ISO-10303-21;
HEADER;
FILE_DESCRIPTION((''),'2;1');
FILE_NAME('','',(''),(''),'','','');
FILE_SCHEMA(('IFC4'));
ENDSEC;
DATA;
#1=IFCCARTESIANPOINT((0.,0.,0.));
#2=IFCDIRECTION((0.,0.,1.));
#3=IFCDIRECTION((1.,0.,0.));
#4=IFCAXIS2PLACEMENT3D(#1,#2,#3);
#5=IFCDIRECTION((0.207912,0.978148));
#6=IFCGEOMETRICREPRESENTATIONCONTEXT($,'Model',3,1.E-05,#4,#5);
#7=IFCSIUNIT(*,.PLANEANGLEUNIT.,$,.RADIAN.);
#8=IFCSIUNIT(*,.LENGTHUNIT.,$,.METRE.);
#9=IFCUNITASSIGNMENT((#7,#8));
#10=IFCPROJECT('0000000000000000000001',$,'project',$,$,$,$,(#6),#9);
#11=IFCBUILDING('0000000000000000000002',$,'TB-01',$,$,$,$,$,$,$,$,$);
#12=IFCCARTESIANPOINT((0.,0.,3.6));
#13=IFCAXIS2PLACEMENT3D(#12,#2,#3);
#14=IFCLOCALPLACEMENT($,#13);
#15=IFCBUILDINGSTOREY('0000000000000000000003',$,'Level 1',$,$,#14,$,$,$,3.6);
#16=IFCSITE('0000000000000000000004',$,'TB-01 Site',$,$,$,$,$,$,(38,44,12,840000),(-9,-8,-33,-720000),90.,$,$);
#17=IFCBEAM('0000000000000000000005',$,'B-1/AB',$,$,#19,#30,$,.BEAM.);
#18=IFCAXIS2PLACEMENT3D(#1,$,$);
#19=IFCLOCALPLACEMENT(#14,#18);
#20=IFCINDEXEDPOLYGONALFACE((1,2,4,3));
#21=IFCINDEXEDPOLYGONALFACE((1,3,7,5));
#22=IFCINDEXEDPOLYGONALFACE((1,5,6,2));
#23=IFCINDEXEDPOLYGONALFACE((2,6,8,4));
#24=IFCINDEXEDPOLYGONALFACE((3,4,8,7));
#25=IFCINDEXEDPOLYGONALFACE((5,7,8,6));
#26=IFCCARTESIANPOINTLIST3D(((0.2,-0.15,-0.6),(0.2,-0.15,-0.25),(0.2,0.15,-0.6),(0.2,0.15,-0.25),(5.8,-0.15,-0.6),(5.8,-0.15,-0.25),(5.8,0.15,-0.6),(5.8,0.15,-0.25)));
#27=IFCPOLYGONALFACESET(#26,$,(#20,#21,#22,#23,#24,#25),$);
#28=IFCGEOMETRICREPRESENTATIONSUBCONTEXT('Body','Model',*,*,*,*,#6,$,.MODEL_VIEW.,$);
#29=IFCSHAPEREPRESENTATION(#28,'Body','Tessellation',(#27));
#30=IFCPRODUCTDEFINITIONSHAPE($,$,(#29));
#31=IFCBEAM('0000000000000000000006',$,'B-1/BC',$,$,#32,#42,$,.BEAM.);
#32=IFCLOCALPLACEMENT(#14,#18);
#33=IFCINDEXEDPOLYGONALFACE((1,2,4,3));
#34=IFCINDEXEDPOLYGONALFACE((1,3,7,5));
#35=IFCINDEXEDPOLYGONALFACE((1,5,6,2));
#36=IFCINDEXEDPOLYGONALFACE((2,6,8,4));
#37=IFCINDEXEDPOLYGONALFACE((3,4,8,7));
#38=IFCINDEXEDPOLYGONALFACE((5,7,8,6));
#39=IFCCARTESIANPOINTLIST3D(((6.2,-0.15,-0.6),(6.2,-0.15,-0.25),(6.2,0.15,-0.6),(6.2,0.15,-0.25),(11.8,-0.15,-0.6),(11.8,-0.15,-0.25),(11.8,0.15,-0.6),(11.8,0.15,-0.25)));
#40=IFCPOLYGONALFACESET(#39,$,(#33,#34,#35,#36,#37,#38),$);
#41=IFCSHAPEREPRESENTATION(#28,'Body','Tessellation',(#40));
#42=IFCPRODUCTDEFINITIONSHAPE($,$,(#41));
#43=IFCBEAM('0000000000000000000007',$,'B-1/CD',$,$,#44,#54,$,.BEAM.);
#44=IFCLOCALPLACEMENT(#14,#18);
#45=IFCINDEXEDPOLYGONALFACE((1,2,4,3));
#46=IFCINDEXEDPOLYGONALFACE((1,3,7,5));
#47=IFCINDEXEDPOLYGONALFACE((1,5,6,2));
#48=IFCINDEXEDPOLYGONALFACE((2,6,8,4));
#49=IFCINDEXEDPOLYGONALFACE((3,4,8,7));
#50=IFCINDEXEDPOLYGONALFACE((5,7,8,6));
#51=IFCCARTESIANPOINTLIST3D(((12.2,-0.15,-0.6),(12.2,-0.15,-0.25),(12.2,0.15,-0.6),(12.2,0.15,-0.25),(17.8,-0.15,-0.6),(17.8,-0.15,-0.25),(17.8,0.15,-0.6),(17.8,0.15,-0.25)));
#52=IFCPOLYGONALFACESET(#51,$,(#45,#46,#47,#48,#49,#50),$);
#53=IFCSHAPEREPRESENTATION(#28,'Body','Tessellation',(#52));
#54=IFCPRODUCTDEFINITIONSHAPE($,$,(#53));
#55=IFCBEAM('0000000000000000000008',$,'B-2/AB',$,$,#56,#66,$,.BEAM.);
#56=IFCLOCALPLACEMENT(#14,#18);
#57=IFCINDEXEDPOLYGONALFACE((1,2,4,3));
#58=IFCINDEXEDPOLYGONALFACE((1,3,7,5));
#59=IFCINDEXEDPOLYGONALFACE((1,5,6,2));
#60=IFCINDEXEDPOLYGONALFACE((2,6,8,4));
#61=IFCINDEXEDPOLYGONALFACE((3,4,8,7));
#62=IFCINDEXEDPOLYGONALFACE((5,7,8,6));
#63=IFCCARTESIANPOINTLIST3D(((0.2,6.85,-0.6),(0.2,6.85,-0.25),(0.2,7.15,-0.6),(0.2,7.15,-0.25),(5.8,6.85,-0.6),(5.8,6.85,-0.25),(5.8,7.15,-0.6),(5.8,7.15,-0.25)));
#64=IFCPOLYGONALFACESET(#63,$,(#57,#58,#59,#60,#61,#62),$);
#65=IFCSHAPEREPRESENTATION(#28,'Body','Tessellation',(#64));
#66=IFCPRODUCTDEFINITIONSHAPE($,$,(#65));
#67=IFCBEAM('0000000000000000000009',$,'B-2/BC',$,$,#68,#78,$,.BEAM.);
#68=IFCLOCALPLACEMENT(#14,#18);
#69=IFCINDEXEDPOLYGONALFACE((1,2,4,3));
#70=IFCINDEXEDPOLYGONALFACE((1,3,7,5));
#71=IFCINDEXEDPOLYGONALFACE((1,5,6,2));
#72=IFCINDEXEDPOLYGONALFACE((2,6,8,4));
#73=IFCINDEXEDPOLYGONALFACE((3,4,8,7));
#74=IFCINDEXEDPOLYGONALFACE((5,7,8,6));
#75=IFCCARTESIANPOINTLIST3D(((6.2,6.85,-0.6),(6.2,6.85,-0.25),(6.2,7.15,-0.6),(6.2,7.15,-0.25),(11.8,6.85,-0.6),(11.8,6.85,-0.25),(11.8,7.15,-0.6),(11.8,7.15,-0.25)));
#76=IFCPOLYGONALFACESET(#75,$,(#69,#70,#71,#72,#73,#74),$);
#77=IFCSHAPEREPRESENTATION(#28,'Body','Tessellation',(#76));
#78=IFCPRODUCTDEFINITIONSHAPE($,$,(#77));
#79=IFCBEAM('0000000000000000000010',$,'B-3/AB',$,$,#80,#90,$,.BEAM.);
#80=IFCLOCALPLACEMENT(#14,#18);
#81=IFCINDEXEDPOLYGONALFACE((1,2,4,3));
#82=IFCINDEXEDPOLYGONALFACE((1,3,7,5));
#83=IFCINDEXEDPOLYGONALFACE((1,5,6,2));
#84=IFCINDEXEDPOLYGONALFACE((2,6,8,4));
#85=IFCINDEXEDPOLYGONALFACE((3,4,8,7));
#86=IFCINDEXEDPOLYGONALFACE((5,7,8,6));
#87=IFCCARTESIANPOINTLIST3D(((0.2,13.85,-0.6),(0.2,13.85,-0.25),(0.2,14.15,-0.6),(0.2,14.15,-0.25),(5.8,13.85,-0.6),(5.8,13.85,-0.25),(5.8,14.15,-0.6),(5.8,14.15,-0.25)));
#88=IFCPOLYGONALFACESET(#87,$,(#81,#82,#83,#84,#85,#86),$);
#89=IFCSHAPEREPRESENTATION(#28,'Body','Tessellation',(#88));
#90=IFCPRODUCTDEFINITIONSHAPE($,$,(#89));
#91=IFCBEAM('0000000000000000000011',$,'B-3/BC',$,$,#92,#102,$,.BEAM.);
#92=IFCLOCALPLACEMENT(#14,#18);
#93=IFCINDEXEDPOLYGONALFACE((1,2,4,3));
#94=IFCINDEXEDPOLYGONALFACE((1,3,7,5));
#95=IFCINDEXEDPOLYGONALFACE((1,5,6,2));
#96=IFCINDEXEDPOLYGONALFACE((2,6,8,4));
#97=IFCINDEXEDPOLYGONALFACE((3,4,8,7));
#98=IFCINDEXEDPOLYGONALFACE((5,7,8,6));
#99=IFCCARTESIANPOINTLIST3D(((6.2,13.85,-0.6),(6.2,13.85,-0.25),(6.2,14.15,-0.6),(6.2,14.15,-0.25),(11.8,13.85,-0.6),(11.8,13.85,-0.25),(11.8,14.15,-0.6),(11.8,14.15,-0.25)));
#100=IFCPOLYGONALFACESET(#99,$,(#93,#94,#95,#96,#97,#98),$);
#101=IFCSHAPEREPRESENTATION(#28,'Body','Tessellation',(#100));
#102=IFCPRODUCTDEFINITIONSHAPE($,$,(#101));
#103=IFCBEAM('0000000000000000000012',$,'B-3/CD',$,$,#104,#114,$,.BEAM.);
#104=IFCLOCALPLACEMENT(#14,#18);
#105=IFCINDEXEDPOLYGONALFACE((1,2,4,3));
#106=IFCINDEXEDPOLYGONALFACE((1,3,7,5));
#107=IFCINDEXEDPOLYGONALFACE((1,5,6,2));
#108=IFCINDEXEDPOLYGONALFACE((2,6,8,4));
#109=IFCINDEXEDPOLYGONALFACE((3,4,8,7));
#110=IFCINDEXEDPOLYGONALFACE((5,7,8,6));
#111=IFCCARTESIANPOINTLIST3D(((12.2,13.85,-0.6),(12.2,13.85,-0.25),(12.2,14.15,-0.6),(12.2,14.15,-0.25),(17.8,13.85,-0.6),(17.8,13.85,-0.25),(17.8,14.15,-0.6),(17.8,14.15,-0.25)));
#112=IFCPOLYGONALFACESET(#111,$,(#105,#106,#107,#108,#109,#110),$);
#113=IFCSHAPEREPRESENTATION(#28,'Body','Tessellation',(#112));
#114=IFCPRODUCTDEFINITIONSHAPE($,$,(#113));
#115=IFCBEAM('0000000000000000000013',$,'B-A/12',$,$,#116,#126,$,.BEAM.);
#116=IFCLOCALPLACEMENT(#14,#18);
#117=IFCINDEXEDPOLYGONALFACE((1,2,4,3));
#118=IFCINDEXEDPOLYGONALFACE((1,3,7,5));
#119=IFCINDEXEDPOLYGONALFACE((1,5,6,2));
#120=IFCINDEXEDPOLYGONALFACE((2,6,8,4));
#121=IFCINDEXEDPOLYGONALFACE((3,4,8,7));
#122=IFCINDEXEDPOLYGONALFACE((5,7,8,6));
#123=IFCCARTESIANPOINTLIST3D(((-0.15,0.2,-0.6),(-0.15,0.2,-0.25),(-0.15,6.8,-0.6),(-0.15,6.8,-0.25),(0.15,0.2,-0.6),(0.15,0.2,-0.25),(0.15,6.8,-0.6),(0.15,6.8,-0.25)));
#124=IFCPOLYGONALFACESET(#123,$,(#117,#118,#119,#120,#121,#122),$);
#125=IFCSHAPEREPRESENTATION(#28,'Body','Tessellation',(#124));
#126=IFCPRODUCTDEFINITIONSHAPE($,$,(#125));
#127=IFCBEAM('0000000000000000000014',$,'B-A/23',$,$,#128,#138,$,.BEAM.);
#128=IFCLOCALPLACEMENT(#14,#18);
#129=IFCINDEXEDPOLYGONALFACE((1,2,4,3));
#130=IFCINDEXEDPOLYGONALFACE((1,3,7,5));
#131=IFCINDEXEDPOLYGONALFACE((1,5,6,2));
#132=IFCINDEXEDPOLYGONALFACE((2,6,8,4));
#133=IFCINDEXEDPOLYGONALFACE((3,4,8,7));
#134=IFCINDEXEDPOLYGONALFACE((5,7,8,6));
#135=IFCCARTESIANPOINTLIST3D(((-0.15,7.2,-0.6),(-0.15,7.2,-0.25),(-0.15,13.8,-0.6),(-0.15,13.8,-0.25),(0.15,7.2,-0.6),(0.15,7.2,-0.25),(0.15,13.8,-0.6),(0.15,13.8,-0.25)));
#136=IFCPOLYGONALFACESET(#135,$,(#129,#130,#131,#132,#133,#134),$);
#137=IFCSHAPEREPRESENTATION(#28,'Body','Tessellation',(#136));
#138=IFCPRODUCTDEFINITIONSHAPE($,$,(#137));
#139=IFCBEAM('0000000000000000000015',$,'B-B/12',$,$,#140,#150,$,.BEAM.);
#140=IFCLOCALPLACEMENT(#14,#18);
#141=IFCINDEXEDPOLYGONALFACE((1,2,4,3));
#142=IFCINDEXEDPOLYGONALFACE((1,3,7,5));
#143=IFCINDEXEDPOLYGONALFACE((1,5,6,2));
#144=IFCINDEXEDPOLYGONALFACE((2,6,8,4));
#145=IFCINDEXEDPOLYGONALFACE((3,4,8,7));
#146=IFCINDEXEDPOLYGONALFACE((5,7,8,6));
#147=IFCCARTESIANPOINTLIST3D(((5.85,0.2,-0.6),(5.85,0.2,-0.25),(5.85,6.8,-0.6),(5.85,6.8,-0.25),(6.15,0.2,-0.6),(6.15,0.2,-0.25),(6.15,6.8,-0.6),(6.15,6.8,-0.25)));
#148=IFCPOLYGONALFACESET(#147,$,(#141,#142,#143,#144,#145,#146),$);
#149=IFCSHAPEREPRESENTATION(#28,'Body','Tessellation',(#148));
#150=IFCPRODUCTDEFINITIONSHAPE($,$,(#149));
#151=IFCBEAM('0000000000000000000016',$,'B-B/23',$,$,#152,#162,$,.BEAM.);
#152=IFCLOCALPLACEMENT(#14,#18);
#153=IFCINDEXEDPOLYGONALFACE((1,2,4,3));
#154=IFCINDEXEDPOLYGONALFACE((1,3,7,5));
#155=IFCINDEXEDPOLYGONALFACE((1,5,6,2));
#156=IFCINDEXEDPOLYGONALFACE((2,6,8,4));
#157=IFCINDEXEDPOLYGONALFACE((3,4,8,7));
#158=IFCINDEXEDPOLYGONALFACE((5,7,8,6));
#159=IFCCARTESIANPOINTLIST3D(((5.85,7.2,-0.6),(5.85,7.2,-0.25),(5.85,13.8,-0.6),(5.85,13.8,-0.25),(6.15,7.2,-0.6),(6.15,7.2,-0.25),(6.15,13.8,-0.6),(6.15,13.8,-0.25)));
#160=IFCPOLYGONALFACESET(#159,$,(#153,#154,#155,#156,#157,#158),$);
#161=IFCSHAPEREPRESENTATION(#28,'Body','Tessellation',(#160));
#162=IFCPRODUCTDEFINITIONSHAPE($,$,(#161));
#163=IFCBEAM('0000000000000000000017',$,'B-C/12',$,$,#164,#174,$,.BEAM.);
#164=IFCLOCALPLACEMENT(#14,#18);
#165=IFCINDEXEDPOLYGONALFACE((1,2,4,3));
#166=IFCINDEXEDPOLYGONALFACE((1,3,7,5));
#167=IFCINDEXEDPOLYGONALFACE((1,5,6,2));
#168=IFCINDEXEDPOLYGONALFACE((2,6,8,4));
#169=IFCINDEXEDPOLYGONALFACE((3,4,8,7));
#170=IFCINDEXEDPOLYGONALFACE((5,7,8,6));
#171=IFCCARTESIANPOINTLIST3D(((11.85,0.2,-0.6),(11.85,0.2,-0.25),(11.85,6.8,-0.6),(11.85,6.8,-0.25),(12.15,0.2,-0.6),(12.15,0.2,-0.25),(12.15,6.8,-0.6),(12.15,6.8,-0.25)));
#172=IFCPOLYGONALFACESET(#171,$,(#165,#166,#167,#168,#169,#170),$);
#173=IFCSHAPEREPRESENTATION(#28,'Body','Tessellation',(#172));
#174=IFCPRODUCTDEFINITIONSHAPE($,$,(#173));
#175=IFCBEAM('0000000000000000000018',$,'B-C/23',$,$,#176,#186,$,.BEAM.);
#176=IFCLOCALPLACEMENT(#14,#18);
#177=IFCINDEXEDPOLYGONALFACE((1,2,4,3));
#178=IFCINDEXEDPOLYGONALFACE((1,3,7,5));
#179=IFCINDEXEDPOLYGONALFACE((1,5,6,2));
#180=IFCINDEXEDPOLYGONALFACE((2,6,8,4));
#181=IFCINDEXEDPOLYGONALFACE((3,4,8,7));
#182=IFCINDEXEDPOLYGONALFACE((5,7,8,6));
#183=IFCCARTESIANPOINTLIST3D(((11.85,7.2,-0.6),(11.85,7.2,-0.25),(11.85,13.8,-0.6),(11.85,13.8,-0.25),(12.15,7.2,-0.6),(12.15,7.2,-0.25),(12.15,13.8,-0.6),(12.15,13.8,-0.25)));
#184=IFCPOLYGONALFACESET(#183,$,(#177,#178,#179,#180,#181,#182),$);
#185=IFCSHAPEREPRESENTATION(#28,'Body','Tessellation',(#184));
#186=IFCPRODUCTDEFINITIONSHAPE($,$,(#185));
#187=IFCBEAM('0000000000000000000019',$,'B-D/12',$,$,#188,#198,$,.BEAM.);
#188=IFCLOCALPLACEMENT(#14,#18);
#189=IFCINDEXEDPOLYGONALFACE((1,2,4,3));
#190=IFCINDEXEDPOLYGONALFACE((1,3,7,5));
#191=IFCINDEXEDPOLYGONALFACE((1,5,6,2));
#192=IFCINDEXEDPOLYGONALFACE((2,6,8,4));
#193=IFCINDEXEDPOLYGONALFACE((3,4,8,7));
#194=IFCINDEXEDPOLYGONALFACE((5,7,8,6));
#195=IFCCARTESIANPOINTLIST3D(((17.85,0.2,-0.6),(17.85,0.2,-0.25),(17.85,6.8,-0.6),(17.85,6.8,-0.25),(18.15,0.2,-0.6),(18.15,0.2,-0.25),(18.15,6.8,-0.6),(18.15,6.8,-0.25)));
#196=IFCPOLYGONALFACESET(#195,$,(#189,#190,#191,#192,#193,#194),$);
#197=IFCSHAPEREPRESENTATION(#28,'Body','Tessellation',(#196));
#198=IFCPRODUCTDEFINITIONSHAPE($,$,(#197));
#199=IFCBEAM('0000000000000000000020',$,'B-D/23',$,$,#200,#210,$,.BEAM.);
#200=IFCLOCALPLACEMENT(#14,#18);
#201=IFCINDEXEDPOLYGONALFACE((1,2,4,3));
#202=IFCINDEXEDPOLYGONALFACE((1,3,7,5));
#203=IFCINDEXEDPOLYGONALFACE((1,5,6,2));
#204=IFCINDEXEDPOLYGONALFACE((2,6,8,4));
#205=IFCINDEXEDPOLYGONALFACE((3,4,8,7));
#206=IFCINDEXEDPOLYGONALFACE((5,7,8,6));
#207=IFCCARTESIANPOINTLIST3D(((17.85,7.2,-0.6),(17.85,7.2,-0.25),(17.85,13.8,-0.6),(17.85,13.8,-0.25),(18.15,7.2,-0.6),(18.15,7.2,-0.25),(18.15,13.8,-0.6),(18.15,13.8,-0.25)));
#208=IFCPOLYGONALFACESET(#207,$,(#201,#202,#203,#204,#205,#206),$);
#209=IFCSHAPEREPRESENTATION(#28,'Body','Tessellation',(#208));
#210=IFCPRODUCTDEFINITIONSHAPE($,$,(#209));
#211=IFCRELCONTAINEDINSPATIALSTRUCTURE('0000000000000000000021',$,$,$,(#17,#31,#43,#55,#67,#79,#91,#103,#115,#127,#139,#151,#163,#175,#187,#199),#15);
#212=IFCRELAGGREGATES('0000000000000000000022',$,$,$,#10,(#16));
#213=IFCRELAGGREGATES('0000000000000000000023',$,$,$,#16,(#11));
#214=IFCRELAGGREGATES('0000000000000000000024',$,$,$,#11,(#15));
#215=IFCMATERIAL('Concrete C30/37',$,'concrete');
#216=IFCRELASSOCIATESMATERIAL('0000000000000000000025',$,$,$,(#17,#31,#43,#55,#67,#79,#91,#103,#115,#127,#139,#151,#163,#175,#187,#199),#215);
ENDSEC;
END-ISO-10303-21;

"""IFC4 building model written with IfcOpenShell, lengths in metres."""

from ifc_helpers import new_model, si_unit, direction, frame, origin_with_axes, place, context, subcontext, project, spatial, rectangle, extrude, material, element, save


model = new_model("IFC4")

# Units and contexts
model_context = context("Model", 3, precision=1e-05, world=origin_with_axes(), true_north=direction((0.207912, 0.978148)))
body_context = subcontext(model_context, "Body", "Model", "MODEL_VIEW")
ifc_project = project(units=[si_unit("PLANEANGLEUNIT", "RADIAN"), si_unit("LENGTHUNIT", "METRE")], contexts=[model_context])

# Site, building, storey
site = spatial("IfcSite", under=ifc_project, Name="TB-01 Site", RefLatitude=(38, 44, 12, 840000), RefLongitude=(-9, -8, -33, -720000), RefElevation=90.0)
building = spatial("IfcBuilding", under=site, Name="TB-01")
storey_placement = place(None, frame((0.0, 0.0, 3.6), z_axis=(0.0, 0.0, 1.0), x_axis=(1.0, 0.0, 0.0)))
storey = spatial("IfcBuildingStorey", under=building, at=storey_placement, Name="Level 1", Elevation=3.6)

# Beams
ifc_material = material(Name="Concrete C30/37", Category="concrete")
beam_1_placement = place(storey_placement, frame((0.2, 0.0, -0.425), z_axis=(1.0, 0.0, 0.0), x_axis=(0.0, 1.0, 0.0)))
element("IfcBeam", 1, at=beam_1_placement, inside=storey, material=ifc_material, Name="B-1/AB", PredefinedType="BEAM", context=body_context, shape_type="SweptSolid", body=[
    extrude(rectangle(XDim=0.3, YDim=0.35), origin_with_axes(), (0.0, 0.0, 1.0), 5.6),
])
beam_2_placement = place(storey_placement, frame((6.2, 0.0, -0.425), z_axis=(1.0, 0.0, 0.0), x_axis=(0.0, 1.0, 0.0)))
element("IfcBeam", 2, at=beam_2_placement, inside=storey, material=ifc_material, Name="B-1/BC", PredefinedType="BEAM", context=body_context, shape_type="SweptSolid", body=[
    extrude(rectangle(XDim=0.3, YDim=0.35), origin_with_axes(), (0.0, 0.0, 1.0), 5.6),
])
beam_3_placement = place(storey_placement, frame((12.2, 0.0, -0.425), z_axis=(1.0, 0.0, 0.0), x_axis=(0.0, 1.0, 0.0)))
element("IfcBeam", 3, at=beam_3_placement, inside=storey, material=ifc_material, Name="B-1/CD", PredefinedType="BEAM", context=body_context, shape_type="SweptSolid", body=[
    extrude(rectangle(XDim=0.3, YDim=0.35), origin_with_axes(), (0.0, 0.0, 1.0), 5.6),
])
beam_4_placement = place(storey_placement, frame((0.2, 7.0, -0.425), z_axis=(1.0, 0.0, 0.0), x_axis=(0.0, 1.0, 0.0)))
element("IfcBeam", 4, at=beam_4_placement, inside=storey, material=ifc_material, Name="B-2/AB", PredefinedType="BEAM", context=body_context, shape_type="SweptSolid", body=[
    extrude(rectangle(XDim=0.3, YDim=0.35), origin_with_axes(), (0.0, 0.0, 1.0), 5.6),
])
beam_5_placement = place(storey_placement, frame((6.2, 7.0, -0.425), z_axis=(1.0, 0.0, 0.0), x_axis=(0.0, 1.0, 0.0)))
element("IfcBeam", 5, at=beam_5_placement, inside=storey, material=ifc_material, Name="B-2/BC", PredefinedType="BEAM", context=body_context, shape_type="SweptSolid", body=[
    extrude(rectangle(XDim=0.3, YDim=0.35), origin_with_axes(), (0.0, 0.0, 1.0), 5.6),
])
beam_6_placement = place(storey_placement, frame((0.2, 14.0, -0.425), z_axis=(1.0, 0.0, 0.0), x_axis=(0.0, 1.0, 0.0)))
element("IfcBeam", 6, at=beam_6_placement, inside=storey, material=ifc_material, Name="B-3/AB", PredefinedType="BEAM", context=body_context, shape_type="SweptSolid", body=[
    extrude(rectangle(XDim=0.3, YDim=0.35), origin_with_axes(), (0.0, 0.0, 1.0), 5.6),
])
beam_7_placement = place(storey_placement, frame((6.2, 14.0, -0.425), z_axis=(1.0, 0.0, 0.0), x_axis=(0.0, 1.0, 0.0)))
element("IfcBeam", 7, at=beam_7_placement, inside=storey, material=ifc_material, Name="B-3/BC", PredefinedType="BEAM", context=body_context, shape_type="SweptSolid", body=[
    extrude(rectangle(XDim=0.3, YDim=0.35), origin_with_axes(), (0.0, 0.0, 1.0), 5.6),
])
beam_8_placement = place(storey_placement, frame((12.2, 14.0, -0.425), z_axis=(1.0, 0.0, 0.0), x_axis=(0.0, 1.0, 0.0)))
element("IfcBeam", 8, at=beam_8_placement, inside=storey, material=ifc_material, Name="B-3/CD", PredefinedType="BEAM", context=body_context, shape_type="SweptSolid", body=[
    extrude(rectangle(XDim=0.3, YDim=0.35), origin_with_axes(), (0.0, 0.0, 1.0), 5.6),
])
beam_9_placement = place(storey_placement, frame((0.0, 0.2, -0.425), z_axis=(0.0, 1.0, 0.0), x_axis=(-1.0, 0.0, 0.0)))
element("IfcBeam", 9, at=beam_9_placement, inside=storey, material=ifc_material, Name="B-A/12", PredefinedType="BEAM", context=body_context, shape_type="SweptSolid", body=[
    extrude(rectangle(XDim=0.3, YDim=0.35), origin_with_axes(), (0.0, 0.0, 1.0), 6.6),
])
beam_10_placement = place(storey_placement, frame((0.0, 7.2, -0.425), z_axis=(0.0, 1.0, 0.0), x_axis=(-1.0, 0.0, 0.0)))
element("IfcBeam", 10, at=beam_10_placement, inside=storey, material=ifc_material, Name="B-A/23", PredefinedType="BEAM", context=body_context, shape_type="SweptSolid", body=[
    extrude(rectangle(XDim=0.3, YDim=0.35), origin_with_axes(), (0.0, 0.0, 1.0), 6.6),
])
beam_11_placement = place(storey_placement, frame((6.0, 0.2, -0.425), z_axis=(0.0, 1.0, 0.0), x_axis=(-1.0, 0.0, 0.0)))
element("IfcBeam", 11, at=beam_11_placement, inside=storey, material=ifc_material, Name="B-B/12", PredefinedType="BEAM", context=body_context, shape_type="SweptSolid", body=[
    extrude(rectangle(XDim=0.3, YDim=0.35), origin_with_axes(), (0.0, 0.0, 1.0), 6.6),
])
beam_12_placement = place(storey_placement, frame((6.0, 7.2, -0.425), z_axis=(0.0, 1.0, 0.0), x_axis=(-1.0, 0.0, 0.0)))
element("IfcBeam", 12, at=beam_12_placement, inside=storey, material=ifc_material, Name="B-B/23", PredefinedType="BEAM", context=body_context, shape_type="SweptSolid", body=[
    extrude(rectangle(XDim=0.3, YDim=0.35), origin_with_axes(), (0.0, 0.0, 1.0), 6.6),
])
beam_13_placement = place(storey_placement, frame((12.0, 0.2, -0.425), z_axis=(0.0, 1.0, 0.0), x_axis=(-1.0, 0.0, 0.0)))
element("IfcBeam", 13, at=beam_13_placement, inside=storey, material=ifc_material, Name="B-C/12", PredefinedType="BEAM", context=body_context, shape_type="SweptSolid", body=[
    extrude(rectangle(XDim=0.3, YDim=0.35), origin_with_axes(), (0.0, 0.0, 1.0), 6.6),
])
beam_14_placement = place(storey_placement, frame((12.0, 7.2, -0.425), z_axis=(0.0, 1.0, 0.0), x_axis=(-1.0, 0.0, 0.0)))
element("IfcBeam", 14, at=beam_14_placement, inside=storey, material=ifc_material, Name="B-C/23", PredefinedType="BEAM", context=body_context, shape_type="SweptSolid", body=[
    extrude(rectangle(XDim=0.3, YDim=0.35), origin_with_axes(), (0.0, 0.0, 1.0), 6.6),
])
beam_15_placement = place(storey_placement, frame((18.0, 0.2, -0.425), z_axis=(0.0, 1.0, 0.0), x_axis=(-1.0, 0.0, 0.0)))
element("IfcBeam", 15, at=beam_15_placement, inside=storey, material=ifc_material, Name="B-D/12", PredefinedType="BEAM", context=body_context, shape_type="SweptSolid", body=[
    extrude(rectangle(XDim=0.3, YDim=0.35), origin_with_axes(), (0.0, 0.0, 1.0), 6.6),
])
beam_16_placement = place(storey_placement, frame((18.0, 7.2, -0.425), z_axis=(0.0, 1.0, 0.0), x_axis=(-1.0, 0.0, 0.0)))
element("IfcBeam", 16, at=beam_16_placement, inside=storey, material=ifc_material, Name="B-D/23", PredefinedType="BEAM", context=body_context, shape_type="SweptSolid", body=[
    extrude(rectangle(XDim=0.3, YDim=0.35), origin_with_axes(), (0.0, 0.0, 1.0), 6.6),
])

save(model, "model.ifc")
